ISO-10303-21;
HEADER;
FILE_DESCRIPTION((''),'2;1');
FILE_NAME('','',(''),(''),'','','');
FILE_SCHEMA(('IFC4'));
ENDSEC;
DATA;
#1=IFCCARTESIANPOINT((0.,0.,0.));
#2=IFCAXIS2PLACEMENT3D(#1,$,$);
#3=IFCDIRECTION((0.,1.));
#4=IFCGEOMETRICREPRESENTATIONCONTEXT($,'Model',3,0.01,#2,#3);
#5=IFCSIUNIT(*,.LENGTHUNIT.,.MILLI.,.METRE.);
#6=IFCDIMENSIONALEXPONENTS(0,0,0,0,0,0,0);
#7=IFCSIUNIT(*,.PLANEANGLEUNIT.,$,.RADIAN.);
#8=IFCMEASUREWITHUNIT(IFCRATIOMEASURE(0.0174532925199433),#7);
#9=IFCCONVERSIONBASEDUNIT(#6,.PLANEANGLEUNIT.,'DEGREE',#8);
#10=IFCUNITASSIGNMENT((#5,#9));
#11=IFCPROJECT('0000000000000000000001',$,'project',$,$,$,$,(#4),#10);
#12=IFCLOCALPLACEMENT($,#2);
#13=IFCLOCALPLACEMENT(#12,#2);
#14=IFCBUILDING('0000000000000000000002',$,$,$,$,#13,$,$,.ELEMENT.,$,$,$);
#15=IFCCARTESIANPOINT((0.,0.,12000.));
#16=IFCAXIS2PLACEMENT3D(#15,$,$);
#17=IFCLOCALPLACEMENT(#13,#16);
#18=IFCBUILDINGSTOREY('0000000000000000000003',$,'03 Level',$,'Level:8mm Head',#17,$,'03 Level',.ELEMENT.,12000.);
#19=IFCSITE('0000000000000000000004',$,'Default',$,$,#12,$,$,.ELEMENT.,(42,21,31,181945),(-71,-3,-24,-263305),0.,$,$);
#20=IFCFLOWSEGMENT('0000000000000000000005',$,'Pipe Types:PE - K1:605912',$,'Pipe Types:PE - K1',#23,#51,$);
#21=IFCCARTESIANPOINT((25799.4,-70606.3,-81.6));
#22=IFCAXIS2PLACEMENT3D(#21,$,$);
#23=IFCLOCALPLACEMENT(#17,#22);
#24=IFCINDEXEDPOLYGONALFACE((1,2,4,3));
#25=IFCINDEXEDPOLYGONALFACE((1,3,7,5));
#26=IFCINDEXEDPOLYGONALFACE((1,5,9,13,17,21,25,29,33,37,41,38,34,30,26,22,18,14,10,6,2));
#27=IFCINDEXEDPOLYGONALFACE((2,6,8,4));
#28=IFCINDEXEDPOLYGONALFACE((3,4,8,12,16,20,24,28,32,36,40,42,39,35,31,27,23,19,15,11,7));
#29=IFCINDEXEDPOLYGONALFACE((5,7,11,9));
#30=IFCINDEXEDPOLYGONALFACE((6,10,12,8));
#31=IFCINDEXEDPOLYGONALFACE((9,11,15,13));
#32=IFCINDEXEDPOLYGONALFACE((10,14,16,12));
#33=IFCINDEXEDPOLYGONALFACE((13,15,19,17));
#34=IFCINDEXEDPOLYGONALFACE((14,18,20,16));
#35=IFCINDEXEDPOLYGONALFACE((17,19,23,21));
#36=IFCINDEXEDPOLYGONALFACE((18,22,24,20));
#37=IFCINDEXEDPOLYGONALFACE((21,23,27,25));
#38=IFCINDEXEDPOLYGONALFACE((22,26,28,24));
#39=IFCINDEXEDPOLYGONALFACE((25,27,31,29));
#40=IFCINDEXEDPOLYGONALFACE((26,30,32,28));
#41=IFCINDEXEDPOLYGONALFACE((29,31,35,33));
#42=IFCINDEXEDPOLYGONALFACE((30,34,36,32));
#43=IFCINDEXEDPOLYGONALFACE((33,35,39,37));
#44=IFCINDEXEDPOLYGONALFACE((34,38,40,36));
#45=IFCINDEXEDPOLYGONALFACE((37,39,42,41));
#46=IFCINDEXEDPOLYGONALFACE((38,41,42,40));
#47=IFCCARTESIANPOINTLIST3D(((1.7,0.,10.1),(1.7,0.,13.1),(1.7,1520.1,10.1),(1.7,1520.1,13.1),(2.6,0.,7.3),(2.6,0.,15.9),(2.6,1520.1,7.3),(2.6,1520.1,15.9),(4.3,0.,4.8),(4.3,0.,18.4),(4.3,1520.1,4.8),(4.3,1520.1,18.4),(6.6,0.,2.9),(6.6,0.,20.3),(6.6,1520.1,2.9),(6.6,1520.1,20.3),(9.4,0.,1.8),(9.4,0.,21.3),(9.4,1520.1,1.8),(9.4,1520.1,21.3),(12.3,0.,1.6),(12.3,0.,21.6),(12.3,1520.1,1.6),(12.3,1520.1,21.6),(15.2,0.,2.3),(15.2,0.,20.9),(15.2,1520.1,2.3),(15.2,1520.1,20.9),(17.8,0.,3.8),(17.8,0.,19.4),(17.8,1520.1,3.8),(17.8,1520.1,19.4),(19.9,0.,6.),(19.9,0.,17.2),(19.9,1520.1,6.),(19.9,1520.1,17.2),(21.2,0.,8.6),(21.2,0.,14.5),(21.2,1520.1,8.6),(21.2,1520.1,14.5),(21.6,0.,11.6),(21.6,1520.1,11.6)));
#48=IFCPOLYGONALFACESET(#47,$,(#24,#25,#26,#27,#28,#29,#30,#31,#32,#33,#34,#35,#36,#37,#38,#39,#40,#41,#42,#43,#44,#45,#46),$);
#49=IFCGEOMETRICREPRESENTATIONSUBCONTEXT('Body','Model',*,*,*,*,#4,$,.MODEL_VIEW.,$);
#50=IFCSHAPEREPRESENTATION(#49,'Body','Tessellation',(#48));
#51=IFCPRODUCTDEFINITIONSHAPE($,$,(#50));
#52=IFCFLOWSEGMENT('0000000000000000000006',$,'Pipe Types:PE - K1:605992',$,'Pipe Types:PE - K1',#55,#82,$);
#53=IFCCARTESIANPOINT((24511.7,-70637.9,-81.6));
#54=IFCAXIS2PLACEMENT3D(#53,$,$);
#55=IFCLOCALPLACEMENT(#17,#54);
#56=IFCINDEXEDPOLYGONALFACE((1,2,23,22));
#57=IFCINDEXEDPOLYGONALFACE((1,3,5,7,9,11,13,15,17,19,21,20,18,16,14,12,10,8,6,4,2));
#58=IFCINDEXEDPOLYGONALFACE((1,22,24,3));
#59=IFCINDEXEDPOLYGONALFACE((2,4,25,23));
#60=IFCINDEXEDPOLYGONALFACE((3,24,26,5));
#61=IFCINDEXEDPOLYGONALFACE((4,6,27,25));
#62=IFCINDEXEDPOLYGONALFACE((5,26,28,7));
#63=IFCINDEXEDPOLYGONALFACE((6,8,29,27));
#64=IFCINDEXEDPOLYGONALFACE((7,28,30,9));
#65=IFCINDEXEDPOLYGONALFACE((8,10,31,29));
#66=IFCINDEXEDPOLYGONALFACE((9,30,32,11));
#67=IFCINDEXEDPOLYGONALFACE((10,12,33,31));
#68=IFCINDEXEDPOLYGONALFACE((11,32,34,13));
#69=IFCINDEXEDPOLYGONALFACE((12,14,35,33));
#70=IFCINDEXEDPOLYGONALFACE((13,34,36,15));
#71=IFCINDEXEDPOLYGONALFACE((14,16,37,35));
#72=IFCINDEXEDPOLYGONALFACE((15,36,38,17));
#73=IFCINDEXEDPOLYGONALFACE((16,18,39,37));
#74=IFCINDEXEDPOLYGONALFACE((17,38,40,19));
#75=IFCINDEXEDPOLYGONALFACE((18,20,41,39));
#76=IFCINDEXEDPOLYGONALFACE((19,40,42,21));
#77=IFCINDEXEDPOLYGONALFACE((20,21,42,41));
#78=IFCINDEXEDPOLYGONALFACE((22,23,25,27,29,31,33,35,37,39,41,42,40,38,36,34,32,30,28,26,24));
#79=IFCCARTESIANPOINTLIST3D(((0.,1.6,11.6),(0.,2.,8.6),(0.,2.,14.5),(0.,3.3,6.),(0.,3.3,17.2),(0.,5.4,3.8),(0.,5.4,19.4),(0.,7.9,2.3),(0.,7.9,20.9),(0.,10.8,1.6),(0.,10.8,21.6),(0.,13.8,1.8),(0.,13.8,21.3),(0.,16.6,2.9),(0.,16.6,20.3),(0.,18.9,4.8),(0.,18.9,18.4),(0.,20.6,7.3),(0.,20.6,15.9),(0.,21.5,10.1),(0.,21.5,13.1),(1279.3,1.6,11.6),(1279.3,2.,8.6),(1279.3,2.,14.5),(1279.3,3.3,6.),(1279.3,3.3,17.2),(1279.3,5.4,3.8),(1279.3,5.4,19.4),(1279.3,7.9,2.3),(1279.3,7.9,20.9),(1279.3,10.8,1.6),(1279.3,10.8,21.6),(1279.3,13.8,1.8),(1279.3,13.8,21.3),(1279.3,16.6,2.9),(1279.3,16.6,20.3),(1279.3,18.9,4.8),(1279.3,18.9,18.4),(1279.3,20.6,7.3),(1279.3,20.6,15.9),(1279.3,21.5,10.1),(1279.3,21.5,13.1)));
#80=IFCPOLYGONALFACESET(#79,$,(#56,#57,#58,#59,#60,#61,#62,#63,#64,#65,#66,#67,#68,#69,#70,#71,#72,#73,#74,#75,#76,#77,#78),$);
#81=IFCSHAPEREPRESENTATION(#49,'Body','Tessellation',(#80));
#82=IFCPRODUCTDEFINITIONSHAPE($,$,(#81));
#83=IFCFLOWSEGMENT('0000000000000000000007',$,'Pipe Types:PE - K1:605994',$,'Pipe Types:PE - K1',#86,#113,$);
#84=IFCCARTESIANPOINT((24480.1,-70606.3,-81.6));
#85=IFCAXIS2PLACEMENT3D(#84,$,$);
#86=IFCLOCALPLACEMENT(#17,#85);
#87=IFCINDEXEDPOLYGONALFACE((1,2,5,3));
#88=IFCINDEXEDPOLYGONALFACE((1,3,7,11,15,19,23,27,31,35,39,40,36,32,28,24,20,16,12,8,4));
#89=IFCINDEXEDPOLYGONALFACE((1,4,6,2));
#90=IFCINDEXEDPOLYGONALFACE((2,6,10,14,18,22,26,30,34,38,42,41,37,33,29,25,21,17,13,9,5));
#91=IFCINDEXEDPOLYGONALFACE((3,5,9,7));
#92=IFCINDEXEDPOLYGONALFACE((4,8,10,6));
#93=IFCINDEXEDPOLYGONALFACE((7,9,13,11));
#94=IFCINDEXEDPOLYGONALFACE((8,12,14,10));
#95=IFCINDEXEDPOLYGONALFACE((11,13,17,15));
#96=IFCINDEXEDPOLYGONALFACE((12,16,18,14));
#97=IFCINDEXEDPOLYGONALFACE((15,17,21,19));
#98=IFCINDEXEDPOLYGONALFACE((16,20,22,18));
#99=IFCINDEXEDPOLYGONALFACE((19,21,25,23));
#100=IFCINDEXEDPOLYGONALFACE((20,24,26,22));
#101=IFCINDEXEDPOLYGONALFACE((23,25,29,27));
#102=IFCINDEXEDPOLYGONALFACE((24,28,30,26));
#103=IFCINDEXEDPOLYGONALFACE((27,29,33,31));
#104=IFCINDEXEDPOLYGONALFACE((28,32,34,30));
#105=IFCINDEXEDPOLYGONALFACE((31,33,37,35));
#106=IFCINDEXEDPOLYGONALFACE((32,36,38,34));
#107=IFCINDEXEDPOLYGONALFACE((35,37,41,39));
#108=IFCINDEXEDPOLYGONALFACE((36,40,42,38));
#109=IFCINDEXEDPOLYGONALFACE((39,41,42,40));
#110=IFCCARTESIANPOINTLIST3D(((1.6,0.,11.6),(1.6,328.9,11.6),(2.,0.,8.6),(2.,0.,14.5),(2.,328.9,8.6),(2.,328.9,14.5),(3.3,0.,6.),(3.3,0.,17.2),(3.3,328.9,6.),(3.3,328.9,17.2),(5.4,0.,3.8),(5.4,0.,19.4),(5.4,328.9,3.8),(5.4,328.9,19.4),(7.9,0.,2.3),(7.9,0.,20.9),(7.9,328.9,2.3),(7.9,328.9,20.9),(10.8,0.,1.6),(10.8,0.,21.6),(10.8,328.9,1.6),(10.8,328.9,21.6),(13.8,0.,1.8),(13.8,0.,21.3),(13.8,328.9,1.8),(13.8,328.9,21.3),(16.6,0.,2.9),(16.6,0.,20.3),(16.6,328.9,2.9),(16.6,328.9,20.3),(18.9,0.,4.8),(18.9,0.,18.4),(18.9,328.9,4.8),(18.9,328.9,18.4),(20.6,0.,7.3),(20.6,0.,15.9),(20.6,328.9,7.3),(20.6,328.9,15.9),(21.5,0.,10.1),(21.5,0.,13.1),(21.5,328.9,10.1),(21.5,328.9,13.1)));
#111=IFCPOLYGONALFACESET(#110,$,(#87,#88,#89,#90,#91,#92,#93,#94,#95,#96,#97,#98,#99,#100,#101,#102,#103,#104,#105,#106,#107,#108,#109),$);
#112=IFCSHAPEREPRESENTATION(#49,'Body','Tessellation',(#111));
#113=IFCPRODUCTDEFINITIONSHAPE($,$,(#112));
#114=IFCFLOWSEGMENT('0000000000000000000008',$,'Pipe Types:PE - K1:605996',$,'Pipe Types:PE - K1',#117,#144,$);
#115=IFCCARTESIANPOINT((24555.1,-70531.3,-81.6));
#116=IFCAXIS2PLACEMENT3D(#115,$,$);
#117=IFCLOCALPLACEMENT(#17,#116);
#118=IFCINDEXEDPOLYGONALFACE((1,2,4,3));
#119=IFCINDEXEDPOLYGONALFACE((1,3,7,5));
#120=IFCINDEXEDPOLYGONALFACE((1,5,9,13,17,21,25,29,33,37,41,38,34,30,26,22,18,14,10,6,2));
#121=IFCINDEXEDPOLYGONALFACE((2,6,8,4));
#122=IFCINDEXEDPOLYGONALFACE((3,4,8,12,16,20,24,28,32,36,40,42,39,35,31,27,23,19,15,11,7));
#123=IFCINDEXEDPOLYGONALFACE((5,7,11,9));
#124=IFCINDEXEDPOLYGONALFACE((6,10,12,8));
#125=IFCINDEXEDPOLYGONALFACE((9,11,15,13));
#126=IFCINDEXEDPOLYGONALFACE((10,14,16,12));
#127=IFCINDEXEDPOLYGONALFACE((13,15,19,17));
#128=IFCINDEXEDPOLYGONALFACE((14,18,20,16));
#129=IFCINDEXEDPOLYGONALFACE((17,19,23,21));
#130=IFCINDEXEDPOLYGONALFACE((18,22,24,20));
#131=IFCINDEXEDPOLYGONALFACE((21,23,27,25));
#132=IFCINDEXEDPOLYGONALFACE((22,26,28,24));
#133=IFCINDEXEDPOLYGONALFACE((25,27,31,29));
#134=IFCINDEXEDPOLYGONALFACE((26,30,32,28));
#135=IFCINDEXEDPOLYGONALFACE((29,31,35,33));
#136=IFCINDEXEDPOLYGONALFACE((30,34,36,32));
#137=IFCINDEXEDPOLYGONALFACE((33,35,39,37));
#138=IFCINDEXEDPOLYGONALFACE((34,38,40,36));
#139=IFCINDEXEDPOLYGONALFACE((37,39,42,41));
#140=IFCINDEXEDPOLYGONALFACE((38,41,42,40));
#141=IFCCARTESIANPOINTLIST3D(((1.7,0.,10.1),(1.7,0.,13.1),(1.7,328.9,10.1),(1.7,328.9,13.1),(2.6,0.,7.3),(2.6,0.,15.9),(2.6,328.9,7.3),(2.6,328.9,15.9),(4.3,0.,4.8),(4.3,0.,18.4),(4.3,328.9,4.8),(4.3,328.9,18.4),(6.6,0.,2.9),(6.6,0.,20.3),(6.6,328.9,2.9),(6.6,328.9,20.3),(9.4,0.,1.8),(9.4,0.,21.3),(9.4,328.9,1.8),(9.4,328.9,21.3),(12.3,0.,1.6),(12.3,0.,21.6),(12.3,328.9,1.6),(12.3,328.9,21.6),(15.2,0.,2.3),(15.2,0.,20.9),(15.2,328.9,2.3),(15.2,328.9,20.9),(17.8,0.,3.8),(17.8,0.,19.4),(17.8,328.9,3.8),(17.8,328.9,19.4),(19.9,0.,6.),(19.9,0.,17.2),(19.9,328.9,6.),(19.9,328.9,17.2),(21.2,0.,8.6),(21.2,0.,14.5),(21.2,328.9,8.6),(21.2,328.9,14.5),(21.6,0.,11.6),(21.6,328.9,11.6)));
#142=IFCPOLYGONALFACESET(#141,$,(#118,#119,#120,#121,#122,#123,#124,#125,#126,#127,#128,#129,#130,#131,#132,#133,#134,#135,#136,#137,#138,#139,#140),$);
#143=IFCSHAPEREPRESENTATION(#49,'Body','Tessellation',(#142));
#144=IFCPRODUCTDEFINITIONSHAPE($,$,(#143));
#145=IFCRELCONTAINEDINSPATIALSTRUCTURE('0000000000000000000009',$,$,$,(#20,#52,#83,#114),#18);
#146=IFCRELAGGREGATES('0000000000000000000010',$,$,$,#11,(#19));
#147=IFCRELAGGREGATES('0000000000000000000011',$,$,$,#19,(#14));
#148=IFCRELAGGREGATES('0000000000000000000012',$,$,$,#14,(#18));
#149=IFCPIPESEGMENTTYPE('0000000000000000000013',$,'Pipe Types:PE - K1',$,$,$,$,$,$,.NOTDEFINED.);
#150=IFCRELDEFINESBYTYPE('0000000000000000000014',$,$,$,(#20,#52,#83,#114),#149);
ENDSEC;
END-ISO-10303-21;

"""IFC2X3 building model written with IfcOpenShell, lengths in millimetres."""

from ifc_helpers import new_model, entity, si_unit, converted_unit, direction, frame, frame_2d, origin, origin_2d_with_axis, place, context, subcontext, project, spatial, circle, extrude, type_object, element, save


model = new_model("IFC2X3")

# Units and contexts
model_context = context("Model", 3, precision=0.01, world=origin(), true_north=direction((0.0, 1.0)))
body_context = subcontext(model_context, "Body", "Model", "MODEL_VIEW")
ifc_project = project(units=[si_unit("LENGTHUNIT", "METRE", prefix="MILLI"), converted_unit("PLANEANGLEUNIT", "DEGREE", entity("IfcRatioMeasure", 0.0174532925199433), si_unit("PLANEANGLEUNIT", "RADIAN"), dimensions=[0, 0, 0, 0, 0, 0, 0])], contexts=[model_context])

# Site, building, storey
site_placement = place(None, origin())
site = spatial("IfcSite", under=ifc_project, at=site_placement, Name="Default", CompositionType="ELEMENT", RefLatitude=(42, 21, 31, 181945), RefLongitude=(-71, -3, -24, -263305), RefElevation=0.0)
building_placement = place(site_placement, origin())
building = spatial("IfcBuilding", under=site, at=building_placement, CompositionType="ELEMENT")
storey_placement = place(building_placement, frame((0.0, 0.0, 12000.0)))
storey = spatial("IfcBuildingStorey", under=building, at=storey_placement, Name="03 Level", ObjectType="Level:8mm Head", LongName="03 Level", CompositionType="ELEMENT", Elevation=12000.0)

# Flow segments
pipe_segment_type = type_object("IfcPipeSegmentType", Name="Pipe Types:PE - K1", PredefinedType="NOTDEFINED")
flow_segment_1_placement = place(storey_placement, frame((25799.4, -70606.3, -81.6)))
element("IfcFlowSegment", 1, at=flow_segment_1_placement, inside=storey, type_object=pipe_segment_type, Name="Pipe Types:PE - K1:605912", ObjectType="Pipe Types:PE - K1", context=body_context, shape_type="SweptSolid", body=[
    extrude(circle(Radius=10.0, at=frame_2d((0.0, 0.0), x_axis=(1.0, 0.0))), frame((11.6, 0.0, 11.6), z_axis=(0.0, 1.0, 0.0), x_axis=(1.0, 0.0, 0.0)), (0.0, 0.0, 1.0), 1520.1),
])
flow_segment_2_placement = place(storey_placement, frame((24511.7, -70637.9, -81.6)))
element("IfcFlowSegment", 2, at=flow_segment_2_placement, inside=storey, type_object=pipe_segment_type, Name="Pipe Types:PE - K1:605992", ObjectType="Pipe Types:PE - K1", context=body_context, shape_type="SweptSolid", body=[
    extrude(circle(Radius=10.0, at=origin_2d_with_axis()), frame((0.0, 11.6, 11.6), z_axis=(1.0, 0.0, 0.0), x_axis=(0.0, -1.0, 0.0)), (0.0, 0.0, 1.0), 1279.3),
])
flow_segment_3_placement = place(storey_placement, frame((24480.1, -70606.3, -81.6)))
element("IfcFlowSegment", 3, at=flow_segment_3_placement, inside=storey, type_object=pipe_segment_type, Name="Pipe Types:PE - K1:605994", ObjectType="Pipe Types:PE - K1", context=body_context, shape_type="SweptSolid", body=[
    extrude(circle(Radius=10.0, at=frame_2d((0.0, 0.0), x_axis=(1.0, 0.0))), frame((11.6, 0.0, 11.6), z_axis=(0.0, 1.0, 0.0), x_axis=(-1.0, 0.0, 0.0)), (0.0, 0.0, 1.0), 328.9),
])
flow_segment_4_placement = place(storey_placement, frame((24555.1, -70531.3, -81.6)))
element("IfcFlowSegment", 4, at=flow_segment_4_placement, inside=storey, type_object=pipe_segment_type, Name="Pipe Types:PE - K1:605996", ObjectType="Pipe Types:PE - K1", context=body_context, shape_type="SweptSolid", body=[
    extrude(circle(Radius=10.0, at=origin_2d_with_axis()), frame((11.6, 0.0, 11.6), z_axis=(0.0, 1.0, 0.0), x_axis=(1.0, 0.0, 0.0)), (0.0, 0.0, 1.0), 328.9),
])

save(model, "model.ifc")
